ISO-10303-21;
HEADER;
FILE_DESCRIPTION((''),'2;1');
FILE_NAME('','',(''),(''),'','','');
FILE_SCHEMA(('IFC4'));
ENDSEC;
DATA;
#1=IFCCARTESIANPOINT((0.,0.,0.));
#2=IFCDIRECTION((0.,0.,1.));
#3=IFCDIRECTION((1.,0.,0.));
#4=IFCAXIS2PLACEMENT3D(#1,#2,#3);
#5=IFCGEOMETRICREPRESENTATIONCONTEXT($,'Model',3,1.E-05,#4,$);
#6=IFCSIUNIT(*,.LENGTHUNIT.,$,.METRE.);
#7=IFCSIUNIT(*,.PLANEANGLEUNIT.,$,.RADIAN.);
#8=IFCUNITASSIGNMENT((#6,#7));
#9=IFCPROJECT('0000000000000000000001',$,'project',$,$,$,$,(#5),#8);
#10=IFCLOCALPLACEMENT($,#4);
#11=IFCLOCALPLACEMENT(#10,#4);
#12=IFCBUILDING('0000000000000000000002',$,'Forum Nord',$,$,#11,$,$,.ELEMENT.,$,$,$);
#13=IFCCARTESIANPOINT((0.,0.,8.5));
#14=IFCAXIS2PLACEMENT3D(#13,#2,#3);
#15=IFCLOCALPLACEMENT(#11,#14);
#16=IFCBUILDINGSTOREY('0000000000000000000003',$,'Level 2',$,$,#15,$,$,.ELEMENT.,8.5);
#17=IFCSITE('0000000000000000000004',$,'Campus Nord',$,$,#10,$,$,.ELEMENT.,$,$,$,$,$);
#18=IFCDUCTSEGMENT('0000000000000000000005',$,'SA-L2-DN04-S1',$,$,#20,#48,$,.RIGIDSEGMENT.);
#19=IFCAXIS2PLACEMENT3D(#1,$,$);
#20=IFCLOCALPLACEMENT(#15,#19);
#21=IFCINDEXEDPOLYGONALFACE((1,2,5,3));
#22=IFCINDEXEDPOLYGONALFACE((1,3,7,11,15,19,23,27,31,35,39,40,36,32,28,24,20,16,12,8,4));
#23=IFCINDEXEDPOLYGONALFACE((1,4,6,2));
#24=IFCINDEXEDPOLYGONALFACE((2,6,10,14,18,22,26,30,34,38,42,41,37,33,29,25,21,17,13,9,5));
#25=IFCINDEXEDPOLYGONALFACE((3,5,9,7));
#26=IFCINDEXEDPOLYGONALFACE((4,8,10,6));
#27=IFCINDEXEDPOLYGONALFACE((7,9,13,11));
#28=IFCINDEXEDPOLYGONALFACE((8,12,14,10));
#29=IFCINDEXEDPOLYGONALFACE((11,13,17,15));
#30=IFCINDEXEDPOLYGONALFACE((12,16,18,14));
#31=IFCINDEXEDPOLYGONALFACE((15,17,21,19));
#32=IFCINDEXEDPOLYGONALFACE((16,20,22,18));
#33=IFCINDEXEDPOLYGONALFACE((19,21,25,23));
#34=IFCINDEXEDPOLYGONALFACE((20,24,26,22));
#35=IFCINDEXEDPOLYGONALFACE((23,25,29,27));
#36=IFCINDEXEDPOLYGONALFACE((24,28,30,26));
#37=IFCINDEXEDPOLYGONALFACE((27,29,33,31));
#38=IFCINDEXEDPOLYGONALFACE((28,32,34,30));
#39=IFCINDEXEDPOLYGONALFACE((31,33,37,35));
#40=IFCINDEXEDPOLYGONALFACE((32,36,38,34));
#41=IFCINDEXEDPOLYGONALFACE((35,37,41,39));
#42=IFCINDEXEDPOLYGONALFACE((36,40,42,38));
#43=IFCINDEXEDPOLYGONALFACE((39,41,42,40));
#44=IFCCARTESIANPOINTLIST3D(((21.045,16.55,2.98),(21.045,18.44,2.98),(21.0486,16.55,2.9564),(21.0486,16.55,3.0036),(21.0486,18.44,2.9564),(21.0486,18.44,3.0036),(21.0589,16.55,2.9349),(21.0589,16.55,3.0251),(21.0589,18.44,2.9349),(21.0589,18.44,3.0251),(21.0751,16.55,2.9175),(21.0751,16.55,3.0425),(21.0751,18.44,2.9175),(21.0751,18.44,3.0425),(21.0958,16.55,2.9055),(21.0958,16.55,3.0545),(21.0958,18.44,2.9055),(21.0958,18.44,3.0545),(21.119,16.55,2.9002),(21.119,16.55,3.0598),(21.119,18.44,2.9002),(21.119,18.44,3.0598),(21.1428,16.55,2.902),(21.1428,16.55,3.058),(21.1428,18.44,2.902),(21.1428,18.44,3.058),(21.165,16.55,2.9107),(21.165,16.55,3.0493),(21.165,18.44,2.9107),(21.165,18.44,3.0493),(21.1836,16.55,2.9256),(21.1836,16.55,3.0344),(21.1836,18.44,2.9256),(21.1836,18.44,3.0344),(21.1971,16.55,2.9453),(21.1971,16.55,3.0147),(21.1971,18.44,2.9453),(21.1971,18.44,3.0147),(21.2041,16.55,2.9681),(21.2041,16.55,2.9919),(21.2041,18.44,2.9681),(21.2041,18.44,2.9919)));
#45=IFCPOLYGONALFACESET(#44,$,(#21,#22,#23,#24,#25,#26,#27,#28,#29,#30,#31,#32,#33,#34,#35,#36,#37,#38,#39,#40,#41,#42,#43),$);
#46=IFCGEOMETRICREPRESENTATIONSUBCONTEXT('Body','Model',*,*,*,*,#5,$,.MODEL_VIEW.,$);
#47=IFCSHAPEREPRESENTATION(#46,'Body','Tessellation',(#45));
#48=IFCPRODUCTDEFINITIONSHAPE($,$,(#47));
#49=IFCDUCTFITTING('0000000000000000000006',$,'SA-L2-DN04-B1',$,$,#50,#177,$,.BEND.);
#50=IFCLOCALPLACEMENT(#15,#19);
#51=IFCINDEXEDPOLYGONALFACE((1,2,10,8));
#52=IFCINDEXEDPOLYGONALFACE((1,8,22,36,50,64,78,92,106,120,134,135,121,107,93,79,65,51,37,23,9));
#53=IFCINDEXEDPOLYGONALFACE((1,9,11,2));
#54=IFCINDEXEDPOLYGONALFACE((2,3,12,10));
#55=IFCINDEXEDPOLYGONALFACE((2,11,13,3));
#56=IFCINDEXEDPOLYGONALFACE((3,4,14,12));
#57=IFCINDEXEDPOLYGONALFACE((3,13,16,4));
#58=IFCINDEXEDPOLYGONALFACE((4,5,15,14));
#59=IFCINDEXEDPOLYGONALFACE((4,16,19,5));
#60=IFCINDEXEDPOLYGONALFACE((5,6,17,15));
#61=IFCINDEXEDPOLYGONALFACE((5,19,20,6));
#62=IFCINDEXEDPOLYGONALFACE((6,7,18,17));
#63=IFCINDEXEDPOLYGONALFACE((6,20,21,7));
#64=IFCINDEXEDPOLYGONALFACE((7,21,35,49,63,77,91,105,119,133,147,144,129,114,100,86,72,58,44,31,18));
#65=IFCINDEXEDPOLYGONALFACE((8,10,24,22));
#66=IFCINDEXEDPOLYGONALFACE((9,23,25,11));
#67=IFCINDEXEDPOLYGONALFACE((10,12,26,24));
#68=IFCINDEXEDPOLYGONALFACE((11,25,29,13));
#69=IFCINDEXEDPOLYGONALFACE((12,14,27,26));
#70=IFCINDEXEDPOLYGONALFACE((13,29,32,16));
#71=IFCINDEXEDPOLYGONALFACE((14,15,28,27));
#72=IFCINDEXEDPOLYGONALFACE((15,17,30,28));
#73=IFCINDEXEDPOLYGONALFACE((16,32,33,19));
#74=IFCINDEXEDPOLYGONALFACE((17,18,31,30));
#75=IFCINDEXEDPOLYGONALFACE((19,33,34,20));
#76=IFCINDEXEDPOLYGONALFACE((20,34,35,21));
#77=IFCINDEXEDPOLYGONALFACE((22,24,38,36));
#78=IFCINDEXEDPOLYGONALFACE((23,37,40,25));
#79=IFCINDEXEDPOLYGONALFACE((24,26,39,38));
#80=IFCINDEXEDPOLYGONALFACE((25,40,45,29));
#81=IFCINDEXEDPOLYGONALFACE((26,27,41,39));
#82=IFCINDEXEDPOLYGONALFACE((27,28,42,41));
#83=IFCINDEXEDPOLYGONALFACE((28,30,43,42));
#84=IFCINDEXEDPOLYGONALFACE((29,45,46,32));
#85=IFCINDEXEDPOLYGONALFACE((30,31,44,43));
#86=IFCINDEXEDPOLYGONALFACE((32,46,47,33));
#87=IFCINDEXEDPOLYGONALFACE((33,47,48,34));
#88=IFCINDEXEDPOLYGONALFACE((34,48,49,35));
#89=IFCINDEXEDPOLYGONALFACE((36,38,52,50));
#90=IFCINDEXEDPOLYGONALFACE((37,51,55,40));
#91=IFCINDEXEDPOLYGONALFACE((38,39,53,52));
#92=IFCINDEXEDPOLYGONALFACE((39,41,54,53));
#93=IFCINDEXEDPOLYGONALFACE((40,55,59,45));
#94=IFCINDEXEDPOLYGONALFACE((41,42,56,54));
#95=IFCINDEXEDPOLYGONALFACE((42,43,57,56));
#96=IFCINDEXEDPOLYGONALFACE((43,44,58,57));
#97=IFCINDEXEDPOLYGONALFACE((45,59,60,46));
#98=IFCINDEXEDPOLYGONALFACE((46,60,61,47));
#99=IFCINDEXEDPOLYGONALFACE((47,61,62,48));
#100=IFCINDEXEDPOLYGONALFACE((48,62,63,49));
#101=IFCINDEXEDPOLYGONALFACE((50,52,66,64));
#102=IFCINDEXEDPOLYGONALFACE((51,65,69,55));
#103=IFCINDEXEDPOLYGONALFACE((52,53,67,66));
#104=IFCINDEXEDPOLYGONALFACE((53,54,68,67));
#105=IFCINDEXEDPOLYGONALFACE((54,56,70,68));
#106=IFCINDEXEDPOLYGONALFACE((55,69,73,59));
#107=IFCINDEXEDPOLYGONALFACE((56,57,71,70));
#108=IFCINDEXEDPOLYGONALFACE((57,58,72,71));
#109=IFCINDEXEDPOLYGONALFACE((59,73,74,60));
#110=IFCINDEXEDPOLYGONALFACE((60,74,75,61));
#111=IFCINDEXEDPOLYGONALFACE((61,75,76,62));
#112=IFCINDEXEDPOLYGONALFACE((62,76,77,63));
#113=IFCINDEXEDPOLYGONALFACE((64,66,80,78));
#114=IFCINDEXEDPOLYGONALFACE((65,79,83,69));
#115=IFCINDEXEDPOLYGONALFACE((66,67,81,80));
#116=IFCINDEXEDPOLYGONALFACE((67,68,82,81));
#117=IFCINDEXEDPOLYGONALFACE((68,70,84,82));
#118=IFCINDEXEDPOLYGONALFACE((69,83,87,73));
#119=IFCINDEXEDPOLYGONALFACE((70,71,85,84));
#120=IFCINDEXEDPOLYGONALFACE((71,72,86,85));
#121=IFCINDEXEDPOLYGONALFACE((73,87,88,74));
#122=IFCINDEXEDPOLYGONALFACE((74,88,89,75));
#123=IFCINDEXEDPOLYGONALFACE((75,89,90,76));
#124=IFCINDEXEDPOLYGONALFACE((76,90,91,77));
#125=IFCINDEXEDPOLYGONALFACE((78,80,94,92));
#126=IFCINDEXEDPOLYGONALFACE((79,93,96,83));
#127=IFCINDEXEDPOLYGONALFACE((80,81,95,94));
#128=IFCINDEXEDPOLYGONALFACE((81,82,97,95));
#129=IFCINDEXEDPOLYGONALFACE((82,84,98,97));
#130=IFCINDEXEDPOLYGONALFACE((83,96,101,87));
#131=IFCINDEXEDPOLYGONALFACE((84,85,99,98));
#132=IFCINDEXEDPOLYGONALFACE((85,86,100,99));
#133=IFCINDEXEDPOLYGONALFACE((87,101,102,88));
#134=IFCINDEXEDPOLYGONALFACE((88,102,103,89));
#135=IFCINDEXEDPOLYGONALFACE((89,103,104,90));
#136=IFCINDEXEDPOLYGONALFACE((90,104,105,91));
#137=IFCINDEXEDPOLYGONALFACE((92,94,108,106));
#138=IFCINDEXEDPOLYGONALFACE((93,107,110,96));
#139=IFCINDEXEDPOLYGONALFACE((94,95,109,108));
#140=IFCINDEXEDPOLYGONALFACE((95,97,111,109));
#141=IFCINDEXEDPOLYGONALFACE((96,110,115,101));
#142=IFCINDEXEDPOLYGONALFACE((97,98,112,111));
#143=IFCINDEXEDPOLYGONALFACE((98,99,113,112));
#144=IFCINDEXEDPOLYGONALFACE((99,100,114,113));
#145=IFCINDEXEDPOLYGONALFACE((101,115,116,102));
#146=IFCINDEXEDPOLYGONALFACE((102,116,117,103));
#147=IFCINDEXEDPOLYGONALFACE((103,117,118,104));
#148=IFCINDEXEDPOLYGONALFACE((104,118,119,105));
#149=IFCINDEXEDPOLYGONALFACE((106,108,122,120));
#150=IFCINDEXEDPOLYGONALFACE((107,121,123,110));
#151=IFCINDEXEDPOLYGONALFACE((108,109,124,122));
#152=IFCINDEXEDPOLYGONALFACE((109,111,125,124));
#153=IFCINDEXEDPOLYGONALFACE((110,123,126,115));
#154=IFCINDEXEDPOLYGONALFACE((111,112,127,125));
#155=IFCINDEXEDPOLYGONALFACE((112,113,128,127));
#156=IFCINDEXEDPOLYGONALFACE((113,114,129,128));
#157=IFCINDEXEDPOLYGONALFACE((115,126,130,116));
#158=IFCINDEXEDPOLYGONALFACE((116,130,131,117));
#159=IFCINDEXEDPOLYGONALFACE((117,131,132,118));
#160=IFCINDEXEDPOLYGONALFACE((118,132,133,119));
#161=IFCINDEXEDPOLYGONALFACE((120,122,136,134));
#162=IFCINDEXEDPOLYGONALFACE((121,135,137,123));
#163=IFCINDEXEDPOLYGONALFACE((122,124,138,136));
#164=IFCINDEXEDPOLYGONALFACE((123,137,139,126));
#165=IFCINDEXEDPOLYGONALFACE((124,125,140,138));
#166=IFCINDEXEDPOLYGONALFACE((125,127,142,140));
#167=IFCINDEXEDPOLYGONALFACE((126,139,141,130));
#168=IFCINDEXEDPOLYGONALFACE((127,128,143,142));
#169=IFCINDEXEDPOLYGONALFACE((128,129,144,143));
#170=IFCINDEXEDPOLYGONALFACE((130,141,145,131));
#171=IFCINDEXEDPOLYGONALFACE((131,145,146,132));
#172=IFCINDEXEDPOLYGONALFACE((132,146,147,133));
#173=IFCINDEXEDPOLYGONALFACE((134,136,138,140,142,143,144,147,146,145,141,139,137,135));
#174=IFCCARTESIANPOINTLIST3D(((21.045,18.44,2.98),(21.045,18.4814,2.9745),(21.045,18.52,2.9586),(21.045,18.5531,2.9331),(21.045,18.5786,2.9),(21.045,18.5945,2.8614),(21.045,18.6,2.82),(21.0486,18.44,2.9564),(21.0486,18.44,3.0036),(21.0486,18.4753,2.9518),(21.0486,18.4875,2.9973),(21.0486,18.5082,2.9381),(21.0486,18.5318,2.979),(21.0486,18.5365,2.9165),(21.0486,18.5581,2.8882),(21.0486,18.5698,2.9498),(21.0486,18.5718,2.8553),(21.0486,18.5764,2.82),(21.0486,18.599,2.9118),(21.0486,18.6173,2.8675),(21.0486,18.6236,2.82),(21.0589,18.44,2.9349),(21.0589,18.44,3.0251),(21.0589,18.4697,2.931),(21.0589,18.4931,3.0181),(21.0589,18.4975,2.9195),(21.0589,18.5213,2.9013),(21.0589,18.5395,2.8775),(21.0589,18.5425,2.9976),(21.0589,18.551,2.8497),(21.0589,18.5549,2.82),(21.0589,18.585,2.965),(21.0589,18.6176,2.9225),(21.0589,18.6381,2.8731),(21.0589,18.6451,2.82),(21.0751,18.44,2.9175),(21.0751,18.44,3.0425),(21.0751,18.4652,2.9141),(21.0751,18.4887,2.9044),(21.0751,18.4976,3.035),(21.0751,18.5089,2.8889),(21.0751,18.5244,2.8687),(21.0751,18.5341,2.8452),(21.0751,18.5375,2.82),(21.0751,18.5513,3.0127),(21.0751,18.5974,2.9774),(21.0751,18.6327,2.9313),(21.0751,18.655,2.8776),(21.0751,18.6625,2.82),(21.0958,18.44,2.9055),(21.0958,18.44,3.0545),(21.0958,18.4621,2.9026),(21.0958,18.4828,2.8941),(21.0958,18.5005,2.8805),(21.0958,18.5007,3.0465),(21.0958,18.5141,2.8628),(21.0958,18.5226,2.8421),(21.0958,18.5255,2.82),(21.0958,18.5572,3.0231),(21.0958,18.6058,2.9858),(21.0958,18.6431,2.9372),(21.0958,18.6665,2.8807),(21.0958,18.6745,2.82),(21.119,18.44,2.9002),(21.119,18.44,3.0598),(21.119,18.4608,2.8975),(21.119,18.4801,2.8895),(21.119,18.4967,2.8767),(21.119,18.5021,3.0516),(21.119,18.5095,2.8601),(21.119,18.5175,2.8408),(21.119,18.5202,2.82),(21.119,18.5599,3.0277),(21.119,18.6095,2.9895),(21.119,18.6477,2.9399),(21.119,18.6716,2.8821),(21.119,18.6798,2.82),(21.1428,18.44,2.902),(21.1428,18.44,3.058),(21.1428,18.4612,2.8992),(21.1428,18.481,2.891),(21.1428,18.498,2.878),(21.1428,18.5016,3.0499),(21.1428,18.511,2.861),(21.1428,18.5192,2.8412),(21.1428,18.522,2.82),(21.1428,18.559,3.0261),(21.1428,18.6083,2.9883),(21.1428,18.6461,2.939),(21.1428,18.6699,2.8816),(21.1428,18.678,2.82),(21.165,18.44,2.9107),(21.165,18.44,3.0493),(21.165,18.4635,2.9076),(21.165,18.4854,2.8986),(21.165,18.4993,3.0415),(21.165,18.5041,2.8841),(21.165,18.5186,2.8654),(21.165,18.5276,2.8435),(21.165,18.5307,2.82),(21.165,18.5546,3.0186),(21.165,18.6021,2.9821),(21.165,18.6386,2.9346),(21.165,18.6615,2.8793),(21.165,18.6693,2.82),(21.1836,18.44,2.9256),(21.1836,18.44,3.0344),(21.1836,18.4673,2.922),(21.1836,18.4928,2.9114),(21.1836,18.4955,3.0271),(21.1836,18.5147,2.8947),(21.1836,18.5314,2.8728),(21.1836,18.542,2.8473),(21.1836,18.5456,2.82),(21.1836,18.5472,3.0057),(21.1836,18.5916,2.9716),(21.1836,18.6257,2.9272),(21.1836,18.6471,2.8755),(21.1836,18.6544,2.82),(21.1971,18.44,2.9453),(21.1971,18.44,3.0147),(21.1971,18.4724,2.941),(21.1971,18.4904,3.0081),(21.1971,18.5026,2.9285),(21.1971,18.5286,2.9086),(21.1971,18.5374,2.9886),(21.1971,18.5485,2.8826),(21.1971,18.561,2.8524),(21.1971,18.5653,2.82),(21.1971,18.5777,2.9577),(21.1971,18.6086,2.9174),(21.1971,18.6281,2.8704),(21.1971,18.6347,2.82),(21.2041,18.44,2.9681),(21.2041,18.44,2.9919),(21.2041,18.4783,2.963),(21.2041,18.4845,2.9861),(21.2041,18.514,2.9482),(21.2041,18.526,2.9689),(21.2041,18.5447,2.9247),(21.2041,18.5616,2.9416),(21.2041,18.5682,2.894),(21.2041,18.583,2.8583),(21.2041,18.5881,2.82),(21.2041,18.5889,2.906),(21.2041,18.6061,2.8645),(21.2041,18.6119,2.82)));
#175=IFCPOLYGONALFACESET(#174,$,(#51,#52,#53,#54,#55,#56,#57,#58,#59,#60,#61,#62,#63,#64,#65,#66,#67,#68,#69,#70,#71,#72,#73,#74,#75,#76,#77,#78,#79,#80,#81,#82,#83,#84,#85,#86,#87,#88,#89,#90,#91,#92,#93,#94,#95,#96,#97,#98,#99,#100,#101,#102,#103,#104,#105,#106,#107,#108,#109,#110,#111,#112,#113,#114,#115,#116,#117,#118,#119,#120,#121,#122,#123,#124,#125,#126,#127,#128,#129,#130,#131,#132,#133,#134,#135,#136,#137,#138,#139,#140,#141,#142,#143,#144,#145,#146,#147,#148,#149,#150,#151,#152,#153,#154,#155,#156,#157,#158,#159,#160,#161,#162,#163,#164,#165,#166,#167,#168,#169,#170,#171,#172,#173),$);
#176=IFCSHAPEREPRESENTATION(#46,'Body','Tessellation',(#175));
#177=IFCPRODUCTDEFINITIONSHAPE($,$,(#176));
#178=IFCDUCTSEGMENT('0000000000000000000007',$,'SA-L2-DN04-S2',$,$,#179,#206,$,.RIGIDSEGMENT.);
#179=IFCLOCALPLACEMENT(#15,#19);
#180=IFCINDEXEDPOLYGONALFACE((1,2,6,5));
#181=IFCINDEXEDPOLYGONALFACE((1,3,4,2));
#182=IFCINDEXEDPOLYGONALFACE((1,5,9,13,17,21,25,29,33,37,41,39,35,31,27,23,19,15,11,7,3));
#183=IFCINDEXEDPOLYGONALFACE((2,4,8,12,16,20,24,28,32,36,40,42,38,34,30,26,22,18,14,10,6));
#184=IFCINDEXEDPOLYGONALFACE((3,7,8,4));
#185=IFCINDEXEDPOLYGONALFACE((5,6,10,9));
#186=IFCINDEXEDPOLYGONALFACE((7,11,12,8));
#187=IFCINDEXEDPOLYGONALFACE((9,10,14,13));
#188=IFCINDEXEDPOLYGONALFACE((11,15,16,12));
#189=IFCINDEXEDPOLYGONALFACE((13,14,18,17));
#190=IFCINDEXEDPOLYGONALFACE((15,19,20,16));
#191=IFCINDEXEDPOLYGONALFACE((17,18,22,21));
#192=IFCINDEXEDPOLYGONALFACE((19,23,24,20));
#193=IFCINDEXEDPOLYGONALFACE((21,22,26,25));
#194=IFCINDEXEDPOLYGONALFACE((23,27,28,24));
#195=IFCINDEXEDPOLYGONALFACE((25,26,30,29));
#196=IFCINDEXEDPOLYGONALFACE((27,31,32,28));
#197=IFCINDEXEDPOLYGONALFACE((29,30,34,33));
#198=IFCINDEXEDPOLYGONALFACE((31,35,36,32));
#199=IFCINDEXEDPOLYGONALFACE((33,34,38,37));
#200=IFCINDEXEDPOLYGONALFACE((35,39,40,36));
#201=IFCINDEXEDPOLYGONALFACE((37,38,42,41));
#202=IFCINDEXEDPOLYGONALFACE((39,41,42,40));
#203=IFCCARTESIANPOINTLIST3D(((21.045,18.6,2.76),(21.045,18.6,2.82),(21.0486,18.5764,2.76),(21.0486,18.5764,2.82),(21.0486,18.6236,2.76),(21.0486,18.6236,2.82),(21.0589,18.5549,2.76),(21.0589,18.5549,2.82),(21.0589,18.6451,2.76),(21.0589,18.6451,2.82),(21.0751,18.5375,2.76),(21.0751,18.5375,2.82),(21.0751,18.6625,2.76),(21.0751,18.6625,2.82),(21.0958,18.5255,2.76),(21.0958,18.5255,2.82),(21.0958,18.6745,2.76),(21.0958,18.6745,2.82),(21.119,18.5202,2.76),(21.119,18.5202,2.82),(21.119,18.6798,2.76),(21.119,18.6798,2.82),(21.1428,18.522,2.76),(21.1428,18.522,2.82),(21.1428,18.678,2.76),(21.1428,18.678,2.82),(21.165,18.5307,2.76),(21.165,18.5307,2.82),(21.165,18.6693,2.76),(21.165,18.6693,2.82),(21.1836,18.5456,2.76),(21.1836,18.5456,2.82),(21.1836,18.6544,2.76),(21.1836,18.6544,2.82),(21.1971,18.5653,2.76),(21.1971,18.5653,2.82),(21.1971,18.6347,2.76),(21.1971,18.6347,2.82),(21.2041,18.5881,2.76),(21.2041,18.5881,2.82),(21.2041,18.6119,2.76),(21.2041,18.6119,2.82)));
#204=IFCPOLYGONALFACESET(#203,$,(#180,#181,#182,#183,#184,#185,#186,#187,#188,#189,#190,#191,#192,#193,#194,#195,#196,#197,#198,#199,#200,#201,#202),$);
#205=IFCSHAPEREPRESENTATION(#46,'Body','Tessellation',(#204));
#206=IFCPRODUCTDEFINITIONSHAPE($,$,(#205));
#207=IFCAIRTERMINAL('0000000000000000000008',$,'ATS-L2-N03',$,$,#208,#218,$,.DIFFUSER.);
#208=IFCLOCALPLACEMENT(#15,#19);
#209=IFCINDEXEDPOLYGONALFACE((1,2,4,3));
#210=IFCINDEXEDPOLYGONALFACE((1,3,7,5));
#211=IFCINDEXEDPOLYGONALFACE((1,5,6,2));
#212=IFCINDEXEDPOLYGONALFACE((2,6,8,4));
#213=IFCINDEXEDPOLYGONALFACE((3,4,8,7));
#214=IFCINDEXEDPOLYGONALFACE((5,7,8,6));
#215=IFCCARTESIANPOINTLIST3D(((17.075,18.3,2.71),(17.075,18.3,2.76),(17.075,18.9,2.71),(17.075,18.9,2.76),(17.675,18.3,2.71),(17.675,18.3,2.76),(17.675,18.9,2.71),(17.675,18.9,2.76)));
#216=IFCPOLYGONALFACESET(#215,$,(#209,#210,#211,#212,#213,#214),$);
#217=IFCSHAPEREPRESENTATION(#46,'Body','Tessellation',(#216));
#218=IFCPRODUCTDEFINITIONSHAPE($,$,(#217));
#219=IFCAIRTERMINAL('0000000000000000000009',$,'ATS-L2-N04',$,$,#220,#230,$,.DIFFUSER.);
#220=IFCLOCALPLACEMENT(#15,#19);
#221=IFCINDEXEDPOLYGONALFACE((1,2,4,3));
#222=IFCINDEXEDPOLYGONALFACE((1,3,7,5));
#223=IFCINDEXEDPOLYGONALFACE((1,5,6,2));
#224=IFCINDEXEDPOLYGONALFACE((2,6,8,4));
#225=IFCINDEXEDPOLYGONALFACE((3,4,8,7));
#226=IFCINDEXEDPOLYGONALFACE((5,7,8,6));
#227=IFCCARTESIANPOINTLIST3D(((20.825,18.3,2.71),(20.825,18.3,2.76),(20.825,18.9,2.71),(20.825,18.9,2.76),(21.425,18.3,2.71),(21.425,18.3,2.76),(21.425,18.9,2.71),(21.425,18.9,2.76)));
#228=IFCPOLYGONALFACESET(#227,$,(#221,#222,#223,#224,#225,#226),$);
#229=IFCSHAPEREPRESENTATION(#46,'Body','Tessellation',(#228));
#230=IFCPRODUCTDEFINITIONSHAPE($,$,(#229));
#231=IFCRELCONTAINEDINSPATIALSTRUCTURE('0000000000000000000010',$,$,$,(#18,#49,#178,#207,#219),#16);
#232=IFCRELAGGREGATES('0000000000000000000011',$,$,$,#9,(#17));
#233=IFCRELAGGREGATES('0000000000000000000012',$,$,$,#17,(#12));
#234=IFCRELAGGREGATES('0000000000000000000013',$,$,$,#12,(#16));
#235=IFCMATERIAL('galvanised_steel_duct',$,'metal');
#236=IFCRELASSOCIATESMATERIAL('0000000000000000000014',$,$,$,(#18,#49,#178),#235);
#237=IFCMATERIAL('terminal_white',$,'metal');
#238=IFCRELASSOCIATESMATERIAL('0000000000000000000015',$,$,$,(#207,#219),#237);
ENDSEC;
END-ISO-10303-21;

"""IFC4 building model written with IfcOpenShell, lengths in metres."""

from ifc_helpers import new_model, entity, si_unit, frame, origin_with_axes, origin_2d_with_axis, place, context, subcontext, project, spatial, rectangle, circle, extrude, material, element, save


model = new_model("IFC4")

# Units and contexts
model_context = context("Model", 3, precision=1e-05, world=origin_with_axes())
body_context = subcontext(model_context, "Body", "Model", "MODEL_VIEW")
ifc_project = project(units=[si_unit("LENGTHUNIT", "METRE"), si_unit("PLANEANGLEUNIT", "RADIAN")], contexts=[model_context])

# Site, building, storey
site_placement = place(None, origin_with_axes())
site = spatial("IfcSite", under=ifc_project, at=site_placement, Name="Campus Nord", CompositionType="ELEMENT")
building_placement = place(site_placement, origin_with_axes())
building = spatial("IfcBuilding", under=site, at=building_placement, Name="Forum Nord", CompositionType="ELEMENT")
storey_placement = place(building_placement, frame((0.0, 0.0, 8.5), z_axis=(0.0, 0.0, 1.0), x_axis=(1.0, 0.0, 0.0)))
storey = spatial("IfcBuildingStorey", under=building, at=storey_placement, Name="Level 2", CompositionType="ELEMENT", Elevation=8.5)

# Shared definitions
ifc_material_1 = material(Name="galvanised_steel_duct", Category="metal")

# Duct segment
duct_segment_1_placement = place(storey_placement, frame((21.125, 16.55, 2.98), z_axis=(0.0, 1.0, 0.0), x_axis=(-1.0, 0.0, 0.0)))
element("IfcDuctSegment", 1, at=duct_segment_1_placement, inside=storey, material=ifc_material_1, Name="SA-L2-DN04-S1", PredefinedType="RIGIDSEGMENT", context=body_context, shape_type="SweptSolid", body=[
    extrude(circle(Radius=0.08, at=origin_2d_with_axis()), origin_with_axes(), (0.0, 0.0, 1.0), 1.89),
])

# Duct fitting
duct_fitting_1_placement = place(storey_placement, frame((21.125, 18.44, 2.98), z_axis=(0.0, 1.0, 0.0), x_axis=(-1.0, 0.0, 0.0)))
ifc_direction_1 = entity("IfcDirection", [1.0, 0.0, 0.0])
element("IfcDuctFitting", 2, at=duct_fitting_1_placement, inside=storey, material=ifc_material_1, Name="SA-L2-DN04-B1", PredefinedType="BEND", context=body_context, shape_type="SweptSolid", body=[
    entity("IfcRevolvedAreaSolid", entity("IfcCircleProfileDef", "AREA", None, entity("IfcAxis2Placement2D", entity("IfcCartesianPoint", [0.0, 0.0]), entity("IfcDirection", [1.0, 0.0])), 0.08), entity("IfcAxis2Placement3D", entity("IfcCartesianPoint", [0.0, 0.0, 0.0]), entity("IfcDirection", [0.0, 0.0, 1.0]), ifc_direction_1), entity("IfcAxis1Placement", entity("IfcCartesianPoint", [0.0, -0.16, 0.0]), ifc_direction_1), 1.5708),
])

# Duct segment
duct_segment_2_placement = place(storey_placement, frame((21.125, 18.6, 2.82), z_axis=(0.0, 0.0, -1.0), x_axis=(-1.0, 0.0, 0.0)))
element("IfcDuctSegment", 3, at=duct_segment_2_placement, inside=storey, material=ifc_material_1, Name="SA-L2-DN04-S2", PredefinedType="RIGIDSEGMENT", context=body_context, shape_type="SweptSolid", body=[
    extrude(circle(Radius=0.08, at=origin_2d_with_axis()), origin_with_axes(), (0.0, 0.0, 1.0), 0.06),
])

# Air terminals
ifc_material_2 = material(Name="terminal_white", Category="metal")
for number, where, z_axis, x_axis, name in (
    (4, (17.375, 18.6, 2.71), (0.0, 0.0, 1.0), (1.0, 0.0, 0.0), "ATS-L2-N03"),
    (5, (21.125, 18.6, 2.71), (0.0, 0.0, 1.0), (1.0, 0.0, 0.0), "ATS-L2-N04"),
):
    element("IfcAirTerminal", number, at=place(storey_placement, frame(where, z_axis=z_axis, x_axis=x_axis)), inside=storey, material=ifc_material_2, Name=name, PredefinedType="DIFFUSER", context=body_context, shape_type="SweptSolid", body=[
        extrude(rectangle(XDim=0.6, YDim=0.6, at=origin_2d_with_axis()), origin_with_axes(), (0.0, 0.0, 1.0), 0.05),
    ])

save(model, "model.ifc")
